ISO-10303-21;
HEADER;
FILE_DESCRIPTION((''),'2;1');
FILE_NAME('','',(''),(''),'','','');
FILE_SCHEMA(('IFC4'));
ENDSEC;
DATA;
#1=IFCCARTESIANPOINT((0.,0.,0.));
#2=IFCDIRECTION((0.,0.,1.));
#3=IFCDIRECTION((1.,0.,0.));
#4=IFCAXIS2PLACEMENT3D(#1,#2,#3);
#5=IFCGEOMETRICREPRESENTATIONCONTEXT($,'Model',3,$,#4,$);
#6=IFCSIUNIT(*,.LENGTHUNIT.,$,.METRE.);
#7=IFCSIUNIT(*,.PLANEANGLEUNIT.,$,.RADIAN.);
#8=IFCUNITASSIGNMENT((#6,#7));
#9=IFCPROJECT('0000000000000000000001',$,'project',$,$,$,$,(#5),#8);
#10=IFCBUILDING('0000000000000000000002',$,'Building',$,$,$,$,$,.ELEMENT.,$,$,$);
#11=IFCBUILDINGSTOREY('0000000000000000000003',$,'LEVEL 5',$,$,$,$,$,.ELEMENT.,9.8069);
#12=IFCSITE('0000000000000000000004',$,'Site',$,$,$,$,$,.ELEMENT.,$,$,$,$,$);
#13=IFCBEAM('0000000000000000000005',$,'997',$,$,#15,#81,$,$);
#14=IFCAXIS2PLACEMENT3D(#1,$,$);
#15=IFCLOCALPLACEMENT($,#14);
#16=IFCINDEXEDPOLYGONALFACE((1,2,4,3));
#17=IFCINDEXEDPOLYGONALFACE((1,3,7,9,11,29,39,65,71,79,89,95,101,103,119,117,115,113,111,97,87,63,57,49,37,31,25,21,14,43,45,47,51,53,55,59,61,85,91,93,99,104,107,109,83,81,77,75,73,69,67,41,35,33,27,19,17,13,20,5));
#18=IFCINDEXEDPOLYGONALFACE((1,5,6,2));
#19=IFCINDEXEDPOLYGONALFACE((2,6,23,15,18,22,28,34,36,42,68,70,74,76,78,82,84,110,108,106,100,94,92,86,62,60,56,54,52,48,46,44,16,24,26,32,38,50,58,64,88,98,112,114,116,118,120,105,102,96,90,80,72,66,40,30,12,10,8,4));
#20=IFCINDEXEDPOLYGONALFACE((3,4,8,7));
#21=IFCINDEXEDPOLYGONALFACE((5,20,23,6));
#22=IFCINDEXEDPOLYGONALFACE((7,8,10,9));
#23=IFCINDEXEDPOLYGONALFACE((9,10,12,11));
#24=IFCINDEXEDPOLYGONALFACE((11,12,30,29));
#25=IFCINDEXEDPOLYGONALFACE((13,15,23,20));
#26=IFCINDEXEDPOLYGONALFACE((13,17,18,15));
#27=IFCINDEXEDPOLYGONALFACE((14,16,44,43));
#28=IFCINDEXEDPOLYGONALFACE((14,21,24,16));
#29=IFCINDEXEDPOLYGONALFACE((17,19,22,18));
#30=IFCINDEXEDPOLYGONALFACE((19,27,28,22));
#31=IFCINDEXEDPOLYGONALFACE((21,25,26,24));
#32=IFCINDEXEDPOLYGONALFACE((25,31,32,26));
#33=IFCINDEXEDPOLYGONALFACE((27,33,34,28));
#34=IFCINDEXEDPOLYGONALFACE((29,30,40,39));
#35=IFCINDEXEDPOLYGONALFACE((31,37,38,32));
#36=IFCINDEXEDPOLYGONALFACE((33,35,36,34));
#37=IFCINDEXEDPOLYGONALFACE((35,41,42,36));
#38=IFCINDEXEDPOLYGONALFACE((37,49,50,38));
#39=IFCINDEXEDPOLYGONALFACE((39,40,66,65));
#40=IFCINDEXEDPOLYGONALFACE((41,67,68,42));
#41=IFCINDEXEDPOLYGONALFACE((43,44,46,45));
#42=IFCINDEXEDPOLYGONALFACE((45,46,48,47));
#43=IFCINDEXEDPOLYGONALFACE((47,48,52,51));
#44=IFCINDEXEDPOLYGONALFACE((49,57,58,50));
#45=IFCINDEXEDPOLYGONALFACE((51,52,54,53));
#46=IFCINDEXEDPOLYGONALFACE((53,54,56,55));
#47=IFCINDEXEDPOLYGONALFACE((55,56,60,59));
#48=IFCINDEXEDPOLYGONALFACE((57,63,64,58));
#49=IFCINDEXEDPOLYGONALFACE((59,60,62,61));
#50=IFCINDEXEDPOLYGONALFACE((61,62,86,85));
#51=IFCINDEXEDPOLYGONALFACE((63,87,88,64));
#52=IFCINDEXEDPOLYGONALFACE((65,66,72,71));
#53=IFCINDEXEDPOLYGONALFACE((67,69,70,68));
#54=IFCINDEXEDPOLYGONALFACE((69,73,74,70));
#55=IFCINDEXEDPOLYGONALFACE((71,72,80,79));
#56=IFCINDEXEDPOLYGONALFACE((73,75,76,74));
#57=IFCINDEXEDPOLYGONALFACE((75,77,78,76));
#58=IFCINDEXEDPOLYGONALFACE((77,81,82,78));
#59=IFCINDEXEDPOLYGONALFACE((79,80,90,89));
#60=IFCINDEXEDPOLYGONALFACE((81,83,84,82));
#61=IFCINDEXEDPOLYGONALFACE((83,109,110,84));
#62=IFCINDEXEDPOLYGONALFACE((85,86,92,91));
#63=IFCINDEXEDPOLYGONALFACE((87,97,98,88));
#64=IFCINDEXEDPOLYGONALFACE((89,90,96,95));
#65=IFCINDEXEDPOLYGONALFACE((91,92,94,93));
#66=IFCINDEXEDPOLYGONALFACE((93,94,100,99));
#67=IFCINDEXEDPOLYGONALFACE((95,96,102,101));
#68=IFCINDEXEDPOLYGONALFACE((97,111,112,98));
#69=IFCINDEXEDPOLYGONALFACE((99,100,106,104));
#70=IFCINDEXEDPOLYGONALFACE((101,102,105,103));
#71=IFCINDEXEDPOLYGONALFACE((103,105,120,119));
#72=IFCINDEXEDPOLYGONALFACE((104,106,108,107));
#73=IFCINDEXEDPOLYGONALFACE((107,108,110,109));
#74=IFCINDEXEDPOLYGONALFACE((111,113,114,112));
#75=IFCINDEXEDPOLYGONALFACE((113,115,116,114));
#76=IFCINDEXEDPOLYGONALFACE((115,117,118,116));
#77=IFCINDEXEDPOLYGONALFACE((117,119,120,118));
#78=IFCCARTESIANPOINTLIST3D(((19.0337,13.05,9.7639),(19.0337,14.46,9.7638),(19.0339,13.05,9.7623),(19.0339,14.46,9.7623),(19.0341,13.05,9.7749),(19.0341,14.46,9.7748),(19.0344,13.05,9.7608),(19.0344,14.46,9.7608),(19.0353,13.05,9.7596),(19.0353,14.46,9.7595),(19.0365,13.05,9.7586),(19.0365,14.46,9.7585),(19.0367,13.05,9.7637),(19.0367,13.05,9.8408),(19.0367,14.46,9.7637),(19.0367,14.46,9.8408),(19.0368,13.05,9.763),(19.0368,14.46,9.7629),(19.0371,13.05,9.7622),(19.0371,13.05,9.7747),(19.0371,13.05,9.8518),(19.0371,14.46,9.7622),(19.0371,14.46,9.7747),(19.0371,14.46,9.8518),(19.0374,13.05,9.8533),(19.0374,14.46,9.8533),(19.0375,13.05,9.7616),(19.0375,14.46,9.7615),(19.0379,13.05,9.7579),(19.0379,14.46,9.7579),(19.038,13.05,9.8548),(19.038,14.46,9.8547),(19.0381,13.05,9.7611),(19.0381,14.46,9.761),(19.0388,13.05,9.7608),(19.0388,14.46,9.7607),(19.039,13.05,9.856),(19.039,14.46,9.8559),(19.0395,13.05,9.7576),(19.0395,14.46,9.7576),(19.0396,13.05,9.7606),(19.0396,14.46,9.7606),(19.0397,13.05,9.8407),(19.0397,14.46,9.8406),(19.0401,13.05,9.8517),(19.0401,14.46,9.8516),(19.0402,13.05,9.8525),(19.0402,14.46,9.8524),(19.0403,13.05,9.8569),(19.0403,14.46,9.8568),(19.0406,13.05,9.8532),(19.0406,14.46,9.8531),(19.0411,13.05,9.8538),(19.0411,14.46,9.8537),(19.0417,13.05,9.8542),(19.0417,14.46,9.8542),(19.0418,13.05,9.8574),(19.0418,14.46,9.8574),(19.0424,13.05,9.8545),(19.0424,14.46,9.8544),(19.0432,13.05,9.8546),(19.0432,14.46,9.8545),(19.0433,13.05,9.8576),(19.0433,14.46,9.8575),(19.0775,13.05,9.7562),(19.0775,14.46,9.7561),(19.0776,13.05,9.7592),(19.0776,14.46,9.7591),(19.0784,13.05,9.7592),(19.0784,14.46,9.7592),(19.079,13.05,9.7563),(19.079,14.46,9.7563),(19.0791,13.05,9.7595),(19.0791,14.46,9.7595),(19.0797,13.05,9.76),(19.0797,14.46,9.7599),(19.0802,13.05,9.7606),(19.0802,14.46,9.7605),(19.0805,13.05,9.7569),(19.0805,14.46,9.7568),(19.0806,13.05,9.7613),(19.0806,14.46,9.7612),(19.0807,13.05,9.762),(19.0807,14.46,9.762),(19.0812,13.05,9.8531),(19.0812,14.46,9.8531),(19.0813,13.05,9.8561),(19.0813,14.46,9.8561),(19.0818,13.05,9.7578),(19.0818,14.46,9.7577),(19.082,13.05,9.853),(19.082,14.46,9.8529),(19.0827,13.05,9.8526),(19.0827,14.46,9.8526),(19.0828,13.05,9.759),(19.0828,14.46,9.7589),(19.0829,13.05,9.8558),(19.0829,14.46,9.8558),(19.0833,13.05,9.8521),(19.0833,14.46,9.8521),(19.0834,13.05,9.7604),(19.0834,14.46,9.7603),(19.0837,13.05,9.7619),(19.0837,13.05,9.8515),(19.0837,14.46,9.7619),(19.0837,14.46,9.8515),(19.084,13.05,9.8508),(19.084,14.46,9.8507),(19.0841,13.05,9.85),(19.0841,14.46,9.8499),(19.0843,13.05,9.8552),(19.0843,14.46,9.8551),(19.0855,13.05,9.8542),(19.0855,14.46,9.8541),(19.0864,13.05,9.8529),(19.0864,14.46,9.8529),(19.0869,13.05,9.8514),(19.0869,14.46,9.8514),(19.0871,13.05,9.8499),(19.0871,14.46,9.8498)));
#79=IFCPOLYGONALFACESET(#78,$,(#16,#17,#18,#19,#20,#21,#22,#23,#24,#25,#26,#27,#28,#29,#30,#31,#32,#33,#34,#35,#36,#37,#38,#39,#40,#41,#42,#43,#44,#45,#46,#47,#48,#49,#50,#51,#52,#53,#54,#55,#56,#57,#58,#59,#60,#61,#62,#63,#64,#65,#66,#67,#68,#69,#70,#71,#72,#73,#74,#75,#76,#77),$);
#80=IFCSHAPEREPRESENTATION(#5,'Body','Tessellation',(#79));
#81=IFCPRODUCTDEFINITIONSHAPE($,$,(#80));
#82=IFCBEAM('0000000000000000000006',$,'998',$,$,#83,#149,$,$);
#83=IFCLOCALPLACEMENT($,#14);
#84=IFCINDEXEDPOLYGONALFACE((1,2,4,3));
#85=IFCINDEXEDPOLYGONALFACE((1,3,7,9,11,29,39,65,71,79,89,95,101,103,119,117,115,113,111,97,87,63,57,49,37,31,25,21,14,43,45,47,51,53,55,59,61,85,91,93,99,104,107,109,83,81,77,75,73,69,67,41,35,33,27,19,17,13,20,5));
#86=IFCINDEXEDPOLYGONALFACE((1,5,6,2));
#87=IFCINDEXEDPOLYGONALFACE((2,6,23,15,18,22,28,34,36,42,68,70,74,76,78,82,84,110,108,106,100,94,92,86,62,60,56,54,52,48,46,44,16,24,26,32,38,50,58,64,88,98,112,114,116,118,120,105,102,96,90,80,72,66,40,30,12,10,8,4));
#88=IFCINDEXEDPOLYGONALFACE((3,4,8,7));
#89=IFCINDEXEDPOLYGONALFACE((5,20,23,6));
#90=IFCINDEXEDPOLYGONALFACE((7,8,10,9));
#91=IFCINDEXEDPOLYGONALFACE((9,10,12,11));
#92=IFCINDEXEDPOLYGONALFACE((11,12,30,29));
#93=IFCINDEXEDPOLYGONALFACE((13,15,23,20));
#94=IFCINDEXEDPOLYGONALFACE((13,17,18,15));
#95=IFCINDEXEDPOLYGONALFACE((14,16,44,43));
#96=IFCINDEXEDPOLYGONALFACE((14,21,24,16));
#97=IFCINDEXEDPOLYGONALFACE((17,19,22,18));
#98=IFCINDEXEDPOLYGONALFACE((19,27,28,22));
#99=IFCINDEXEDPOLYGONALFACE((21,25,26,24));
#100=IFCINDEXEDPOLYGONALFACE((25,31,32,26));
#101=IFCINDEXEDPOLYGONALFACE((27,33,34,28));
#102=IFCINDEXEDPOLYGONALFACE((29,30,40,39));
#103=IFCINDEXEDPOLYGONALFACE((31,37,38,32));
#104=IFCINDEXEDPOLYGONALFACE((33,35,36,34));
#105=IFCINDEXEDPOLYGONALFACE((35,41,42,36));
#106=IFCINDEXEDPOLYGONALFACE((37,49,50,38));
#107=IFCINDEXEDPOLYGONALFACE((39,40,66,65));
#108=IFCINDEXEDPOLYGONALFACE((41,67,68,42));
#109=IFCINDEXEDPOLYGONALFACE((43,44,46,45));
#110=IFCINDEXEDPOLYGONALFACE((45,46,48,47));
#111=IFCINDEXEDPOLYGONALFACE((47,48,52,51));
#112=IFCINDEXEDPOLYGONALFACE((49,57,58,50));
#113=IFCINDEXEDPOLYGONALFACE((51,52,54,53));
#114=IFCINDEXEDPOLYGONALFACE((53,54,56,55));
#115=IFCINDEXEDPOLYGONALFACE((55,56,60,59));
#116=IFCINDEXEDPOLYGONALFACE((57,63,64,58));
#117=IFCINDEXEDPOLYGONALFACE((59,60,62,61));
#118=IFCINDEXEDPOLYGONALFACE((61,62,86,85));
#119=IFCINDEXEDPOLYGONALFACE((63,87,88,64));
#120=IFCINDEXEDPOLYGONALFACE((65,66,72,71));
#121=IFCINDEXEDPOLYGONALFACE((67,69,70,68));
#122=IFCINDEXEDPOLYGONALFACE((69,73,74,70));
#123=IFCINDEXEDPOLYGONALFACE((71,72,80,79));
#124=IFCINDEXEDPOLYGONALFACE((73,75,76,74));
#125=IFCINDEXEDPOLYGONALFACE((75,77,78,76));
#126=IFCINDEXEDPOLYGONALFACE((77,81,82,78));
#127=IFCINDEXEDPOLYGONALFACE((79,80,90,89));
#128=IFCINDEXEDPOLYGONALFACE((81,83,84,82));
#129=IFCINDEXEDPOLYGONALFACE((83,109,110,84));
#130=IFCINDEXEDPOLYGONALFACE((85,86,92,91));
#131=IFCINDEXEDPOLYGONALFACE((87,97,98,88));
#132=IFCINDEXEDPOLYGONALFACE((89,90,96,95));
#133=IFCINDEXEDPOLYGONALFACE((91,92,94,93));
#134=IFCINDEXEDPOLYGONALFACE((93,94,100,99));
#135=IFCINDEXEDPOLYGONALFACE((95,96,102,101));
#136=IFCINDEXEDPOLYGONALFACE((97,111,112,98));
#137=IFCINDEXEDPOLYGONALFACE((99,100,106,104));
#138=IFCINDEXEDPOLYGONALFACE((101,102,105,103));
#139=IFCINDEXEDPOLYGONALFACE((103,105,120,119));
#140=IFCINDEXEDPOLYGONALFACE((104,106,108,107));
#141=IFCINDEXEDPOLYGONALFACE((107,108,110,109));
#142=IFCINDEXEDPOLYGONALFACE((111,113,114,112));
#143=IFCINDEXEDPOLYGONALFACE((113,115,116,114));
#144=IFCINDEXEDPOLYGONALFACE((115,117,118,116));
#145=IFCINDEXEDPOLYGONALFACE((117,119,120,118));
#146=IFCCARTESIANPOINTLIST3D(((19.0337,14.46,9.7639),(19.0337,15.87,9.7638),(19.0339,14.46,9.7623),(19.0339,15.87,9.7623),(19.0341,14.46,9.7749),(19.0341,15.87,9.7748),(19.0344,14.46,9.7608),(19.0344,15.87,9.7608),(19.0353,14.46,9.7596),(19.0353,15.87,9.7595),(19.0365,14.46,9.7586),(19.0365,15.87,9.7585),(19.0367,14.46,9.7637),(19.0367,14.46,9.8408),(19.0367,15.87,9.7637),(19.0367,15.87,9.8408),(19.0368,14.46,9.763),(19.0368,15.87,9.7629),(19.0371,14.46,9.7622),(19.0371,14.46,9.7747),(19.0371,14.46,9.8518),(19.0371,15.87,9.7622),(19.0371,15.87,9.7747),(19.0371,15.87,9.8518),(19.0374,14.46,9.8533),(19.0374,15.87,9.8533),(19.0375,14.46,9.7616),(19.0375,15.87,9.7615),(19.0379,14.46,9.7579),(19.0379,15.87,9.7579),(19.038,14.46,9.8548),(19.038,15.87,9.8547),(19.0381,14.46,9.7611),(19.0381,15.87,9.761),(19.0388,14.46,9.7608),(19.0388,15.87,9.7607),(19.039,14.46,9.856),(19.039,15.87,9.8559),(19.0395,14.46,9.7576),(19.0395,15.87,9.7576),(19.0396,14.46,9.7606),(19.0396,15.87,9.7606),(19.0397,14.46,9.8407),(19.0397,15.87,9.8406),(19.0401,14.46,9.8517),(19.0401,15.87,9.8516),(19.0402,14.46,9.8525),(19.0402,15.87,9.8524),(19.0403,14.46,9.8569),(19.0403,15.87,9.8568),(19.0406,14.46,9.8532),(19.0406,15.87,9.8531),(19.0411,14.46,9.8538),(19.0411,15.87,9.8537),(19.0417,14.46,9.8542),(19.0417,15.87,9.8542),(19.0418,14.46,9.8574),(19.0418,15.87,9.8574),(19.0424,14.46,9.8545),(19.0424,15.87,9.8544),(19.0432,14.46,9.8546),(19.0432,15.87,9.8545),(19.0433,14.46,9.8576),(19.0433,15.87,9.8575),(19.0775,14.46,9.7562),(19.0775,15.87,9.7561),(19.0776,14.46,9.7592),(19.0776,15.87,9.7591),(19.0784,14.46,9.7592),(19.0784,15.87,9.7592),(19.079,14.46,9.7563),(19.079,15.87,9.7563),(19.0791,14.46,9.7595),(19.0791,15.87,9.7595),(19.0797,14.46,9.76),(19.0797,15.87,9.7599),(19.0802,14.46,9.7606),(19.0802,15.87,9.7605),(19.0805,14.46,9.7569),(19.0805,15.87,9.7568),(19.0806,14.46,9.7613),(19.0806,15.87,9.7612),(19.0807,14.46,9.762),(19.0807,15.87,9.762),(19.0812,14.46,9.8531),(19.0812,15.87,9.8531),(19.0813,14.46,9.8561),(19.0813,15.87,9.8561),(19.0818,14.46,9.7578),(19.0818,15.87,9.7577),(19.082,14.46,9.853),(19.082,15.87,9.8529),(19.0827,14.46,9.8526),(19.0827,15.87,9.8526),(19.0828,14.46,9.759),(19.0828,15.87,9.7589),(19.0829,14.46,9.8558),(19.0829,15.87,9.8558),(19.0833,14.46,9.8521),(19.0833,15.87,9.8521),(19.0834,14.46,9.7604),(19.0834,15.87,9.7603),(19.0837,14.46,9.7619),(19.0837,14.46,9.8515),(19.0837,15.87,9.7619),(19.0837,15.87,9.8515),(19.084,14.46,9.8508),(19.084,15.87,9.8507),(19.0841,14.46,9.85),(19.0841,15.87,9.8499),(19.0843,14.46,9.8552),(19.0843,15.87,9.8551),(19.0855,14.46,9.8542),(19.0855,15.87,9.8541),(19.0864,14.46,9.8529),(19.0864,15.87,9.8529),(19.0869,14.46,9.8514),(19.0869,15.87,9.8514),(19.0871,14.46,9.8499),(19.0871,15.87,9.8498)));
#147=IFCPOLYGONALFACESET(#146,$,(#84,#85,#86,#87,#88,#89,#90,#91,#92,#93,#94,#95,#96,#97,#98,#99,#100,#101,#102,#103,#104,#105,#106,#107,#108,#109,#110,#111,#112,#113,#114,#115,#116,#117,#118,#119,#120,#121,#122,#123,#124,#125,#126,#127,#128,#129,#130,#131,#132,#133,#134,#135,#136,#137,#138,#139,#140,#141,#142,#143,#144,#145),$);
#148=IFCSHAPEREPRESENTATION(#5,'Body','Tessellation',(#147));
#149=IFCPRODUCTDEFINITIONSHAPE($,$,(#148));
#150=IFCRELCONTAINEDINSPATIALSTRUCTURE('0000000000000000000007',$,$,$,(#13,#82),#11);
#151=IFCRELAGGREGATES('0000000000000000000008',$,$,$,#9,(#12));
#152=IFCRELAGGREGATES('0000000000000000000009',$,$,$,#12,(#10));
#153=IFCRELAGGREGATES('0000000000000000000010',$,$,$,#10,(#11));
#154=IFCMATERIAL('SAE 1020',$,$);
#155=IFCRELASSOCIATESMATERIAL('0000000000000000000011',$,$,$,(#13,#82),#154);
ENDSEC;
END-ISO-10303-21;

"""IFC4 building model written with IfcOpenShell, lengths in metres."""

from ifc_helpers import new_model, si_unit, frame, origin_with_axes, origin_2d_with_axis, place, context, project, spatial, c_section, extrude, material, material_profile, profile_set, profile_usage, element, save


model = new_model("IFC4")

# Units and contexts
model_context = context("Model", 3, world=origin_with_axes())
ifc_project = project(units=[si_unit("LENGTHUNIT", "METRE"), si_unit("PLANEANGLEUNIT", "RADIAN")], contexts=[model_context])

# Site, building, storey
site = spatial("IfcSite", under=ifc_project, Name="Site", CompositionType="ELEMENT")
building = spatial("IfcBuilding", under=site, Name="Building", CompositionType="ELEMENT")
storey = spatial("IfcBuildingStorey", under=building, Name="LEVEL 5", CompositionType="ELEMENT", Elevation=9.8069)

# Beams
ifc_material = material(Name="SAE 1020")
ifc_material_profile_1 = material_profile(ifc_material, c_section(Depth=0.1, Width=0.05, WallThickness=0.003, Girth=0.017, InternalFilletRadius=0.003, at=origin_2d_with_axis()))
ifc_profile_set_1 = profile_set([ifc_material_profile_1])
ifc_profile_usage_1 = profile_usage(ifc_profile_set_1, cardinal=10)
beam_1_placement = place(None, frame((19.0604, 13.05, 9.8069), z_axis=(0.0, 1.0, -0.00003), x_axis=(-0.999256, 0.000001, 0.038562)))
element("IfcBeam", 1, at=beam_1_placement, inside=storey, material=ifc_profile_usage_1, Name="997", context=model_context, shape_type="SweptSolid", body=[
    extrude(c_section(Depth=0.1, Width=0.05, WallThickness=0.003, Girth=0.017, InternalFilletRadius=0.003, at=origin_2d_with_axis()), origin_with_axes(), (0.0, 0.0, 1.0), 1.41),
])
ifc_material_profile_2 = material_profile(ifc_material, c_section(Depth=0.1, Width=0.05, WallThickness=0.003, Girth=0.017, InternalFilletRadius=0.003, at=origin_2d_with_axis()))
ifc_profile_set_2 = profile_set([ifc_material_profile_2])
ifc_profile_usage_2 = profile_usage(ifc_profile_set_2, cardinal=10)
beam_2_placement = place(None, frame((19.0604, 14.46, 9.8069), z_axis=(0.0, 1.0, -0.00003), x_axis=(-0.999256, 0.000001, 0.038562)))
element("IfcBeam", 2, at=beam_2_placement, inside=storey, material=ifc_profile_usage_2, Name="998", context=model_context, shape_type="SweptSolid", body=[
    extrude(c_section(Depth=0.1, Width=0.05, WallThickness=0.003, Girth=0.017, InternalFilletRadius=0.003, at=origin_2d_with_axis()), origin_with_axes(), (0.0, 0.0, 1.0), 1.41),
])

save(model, "model.ifc")
